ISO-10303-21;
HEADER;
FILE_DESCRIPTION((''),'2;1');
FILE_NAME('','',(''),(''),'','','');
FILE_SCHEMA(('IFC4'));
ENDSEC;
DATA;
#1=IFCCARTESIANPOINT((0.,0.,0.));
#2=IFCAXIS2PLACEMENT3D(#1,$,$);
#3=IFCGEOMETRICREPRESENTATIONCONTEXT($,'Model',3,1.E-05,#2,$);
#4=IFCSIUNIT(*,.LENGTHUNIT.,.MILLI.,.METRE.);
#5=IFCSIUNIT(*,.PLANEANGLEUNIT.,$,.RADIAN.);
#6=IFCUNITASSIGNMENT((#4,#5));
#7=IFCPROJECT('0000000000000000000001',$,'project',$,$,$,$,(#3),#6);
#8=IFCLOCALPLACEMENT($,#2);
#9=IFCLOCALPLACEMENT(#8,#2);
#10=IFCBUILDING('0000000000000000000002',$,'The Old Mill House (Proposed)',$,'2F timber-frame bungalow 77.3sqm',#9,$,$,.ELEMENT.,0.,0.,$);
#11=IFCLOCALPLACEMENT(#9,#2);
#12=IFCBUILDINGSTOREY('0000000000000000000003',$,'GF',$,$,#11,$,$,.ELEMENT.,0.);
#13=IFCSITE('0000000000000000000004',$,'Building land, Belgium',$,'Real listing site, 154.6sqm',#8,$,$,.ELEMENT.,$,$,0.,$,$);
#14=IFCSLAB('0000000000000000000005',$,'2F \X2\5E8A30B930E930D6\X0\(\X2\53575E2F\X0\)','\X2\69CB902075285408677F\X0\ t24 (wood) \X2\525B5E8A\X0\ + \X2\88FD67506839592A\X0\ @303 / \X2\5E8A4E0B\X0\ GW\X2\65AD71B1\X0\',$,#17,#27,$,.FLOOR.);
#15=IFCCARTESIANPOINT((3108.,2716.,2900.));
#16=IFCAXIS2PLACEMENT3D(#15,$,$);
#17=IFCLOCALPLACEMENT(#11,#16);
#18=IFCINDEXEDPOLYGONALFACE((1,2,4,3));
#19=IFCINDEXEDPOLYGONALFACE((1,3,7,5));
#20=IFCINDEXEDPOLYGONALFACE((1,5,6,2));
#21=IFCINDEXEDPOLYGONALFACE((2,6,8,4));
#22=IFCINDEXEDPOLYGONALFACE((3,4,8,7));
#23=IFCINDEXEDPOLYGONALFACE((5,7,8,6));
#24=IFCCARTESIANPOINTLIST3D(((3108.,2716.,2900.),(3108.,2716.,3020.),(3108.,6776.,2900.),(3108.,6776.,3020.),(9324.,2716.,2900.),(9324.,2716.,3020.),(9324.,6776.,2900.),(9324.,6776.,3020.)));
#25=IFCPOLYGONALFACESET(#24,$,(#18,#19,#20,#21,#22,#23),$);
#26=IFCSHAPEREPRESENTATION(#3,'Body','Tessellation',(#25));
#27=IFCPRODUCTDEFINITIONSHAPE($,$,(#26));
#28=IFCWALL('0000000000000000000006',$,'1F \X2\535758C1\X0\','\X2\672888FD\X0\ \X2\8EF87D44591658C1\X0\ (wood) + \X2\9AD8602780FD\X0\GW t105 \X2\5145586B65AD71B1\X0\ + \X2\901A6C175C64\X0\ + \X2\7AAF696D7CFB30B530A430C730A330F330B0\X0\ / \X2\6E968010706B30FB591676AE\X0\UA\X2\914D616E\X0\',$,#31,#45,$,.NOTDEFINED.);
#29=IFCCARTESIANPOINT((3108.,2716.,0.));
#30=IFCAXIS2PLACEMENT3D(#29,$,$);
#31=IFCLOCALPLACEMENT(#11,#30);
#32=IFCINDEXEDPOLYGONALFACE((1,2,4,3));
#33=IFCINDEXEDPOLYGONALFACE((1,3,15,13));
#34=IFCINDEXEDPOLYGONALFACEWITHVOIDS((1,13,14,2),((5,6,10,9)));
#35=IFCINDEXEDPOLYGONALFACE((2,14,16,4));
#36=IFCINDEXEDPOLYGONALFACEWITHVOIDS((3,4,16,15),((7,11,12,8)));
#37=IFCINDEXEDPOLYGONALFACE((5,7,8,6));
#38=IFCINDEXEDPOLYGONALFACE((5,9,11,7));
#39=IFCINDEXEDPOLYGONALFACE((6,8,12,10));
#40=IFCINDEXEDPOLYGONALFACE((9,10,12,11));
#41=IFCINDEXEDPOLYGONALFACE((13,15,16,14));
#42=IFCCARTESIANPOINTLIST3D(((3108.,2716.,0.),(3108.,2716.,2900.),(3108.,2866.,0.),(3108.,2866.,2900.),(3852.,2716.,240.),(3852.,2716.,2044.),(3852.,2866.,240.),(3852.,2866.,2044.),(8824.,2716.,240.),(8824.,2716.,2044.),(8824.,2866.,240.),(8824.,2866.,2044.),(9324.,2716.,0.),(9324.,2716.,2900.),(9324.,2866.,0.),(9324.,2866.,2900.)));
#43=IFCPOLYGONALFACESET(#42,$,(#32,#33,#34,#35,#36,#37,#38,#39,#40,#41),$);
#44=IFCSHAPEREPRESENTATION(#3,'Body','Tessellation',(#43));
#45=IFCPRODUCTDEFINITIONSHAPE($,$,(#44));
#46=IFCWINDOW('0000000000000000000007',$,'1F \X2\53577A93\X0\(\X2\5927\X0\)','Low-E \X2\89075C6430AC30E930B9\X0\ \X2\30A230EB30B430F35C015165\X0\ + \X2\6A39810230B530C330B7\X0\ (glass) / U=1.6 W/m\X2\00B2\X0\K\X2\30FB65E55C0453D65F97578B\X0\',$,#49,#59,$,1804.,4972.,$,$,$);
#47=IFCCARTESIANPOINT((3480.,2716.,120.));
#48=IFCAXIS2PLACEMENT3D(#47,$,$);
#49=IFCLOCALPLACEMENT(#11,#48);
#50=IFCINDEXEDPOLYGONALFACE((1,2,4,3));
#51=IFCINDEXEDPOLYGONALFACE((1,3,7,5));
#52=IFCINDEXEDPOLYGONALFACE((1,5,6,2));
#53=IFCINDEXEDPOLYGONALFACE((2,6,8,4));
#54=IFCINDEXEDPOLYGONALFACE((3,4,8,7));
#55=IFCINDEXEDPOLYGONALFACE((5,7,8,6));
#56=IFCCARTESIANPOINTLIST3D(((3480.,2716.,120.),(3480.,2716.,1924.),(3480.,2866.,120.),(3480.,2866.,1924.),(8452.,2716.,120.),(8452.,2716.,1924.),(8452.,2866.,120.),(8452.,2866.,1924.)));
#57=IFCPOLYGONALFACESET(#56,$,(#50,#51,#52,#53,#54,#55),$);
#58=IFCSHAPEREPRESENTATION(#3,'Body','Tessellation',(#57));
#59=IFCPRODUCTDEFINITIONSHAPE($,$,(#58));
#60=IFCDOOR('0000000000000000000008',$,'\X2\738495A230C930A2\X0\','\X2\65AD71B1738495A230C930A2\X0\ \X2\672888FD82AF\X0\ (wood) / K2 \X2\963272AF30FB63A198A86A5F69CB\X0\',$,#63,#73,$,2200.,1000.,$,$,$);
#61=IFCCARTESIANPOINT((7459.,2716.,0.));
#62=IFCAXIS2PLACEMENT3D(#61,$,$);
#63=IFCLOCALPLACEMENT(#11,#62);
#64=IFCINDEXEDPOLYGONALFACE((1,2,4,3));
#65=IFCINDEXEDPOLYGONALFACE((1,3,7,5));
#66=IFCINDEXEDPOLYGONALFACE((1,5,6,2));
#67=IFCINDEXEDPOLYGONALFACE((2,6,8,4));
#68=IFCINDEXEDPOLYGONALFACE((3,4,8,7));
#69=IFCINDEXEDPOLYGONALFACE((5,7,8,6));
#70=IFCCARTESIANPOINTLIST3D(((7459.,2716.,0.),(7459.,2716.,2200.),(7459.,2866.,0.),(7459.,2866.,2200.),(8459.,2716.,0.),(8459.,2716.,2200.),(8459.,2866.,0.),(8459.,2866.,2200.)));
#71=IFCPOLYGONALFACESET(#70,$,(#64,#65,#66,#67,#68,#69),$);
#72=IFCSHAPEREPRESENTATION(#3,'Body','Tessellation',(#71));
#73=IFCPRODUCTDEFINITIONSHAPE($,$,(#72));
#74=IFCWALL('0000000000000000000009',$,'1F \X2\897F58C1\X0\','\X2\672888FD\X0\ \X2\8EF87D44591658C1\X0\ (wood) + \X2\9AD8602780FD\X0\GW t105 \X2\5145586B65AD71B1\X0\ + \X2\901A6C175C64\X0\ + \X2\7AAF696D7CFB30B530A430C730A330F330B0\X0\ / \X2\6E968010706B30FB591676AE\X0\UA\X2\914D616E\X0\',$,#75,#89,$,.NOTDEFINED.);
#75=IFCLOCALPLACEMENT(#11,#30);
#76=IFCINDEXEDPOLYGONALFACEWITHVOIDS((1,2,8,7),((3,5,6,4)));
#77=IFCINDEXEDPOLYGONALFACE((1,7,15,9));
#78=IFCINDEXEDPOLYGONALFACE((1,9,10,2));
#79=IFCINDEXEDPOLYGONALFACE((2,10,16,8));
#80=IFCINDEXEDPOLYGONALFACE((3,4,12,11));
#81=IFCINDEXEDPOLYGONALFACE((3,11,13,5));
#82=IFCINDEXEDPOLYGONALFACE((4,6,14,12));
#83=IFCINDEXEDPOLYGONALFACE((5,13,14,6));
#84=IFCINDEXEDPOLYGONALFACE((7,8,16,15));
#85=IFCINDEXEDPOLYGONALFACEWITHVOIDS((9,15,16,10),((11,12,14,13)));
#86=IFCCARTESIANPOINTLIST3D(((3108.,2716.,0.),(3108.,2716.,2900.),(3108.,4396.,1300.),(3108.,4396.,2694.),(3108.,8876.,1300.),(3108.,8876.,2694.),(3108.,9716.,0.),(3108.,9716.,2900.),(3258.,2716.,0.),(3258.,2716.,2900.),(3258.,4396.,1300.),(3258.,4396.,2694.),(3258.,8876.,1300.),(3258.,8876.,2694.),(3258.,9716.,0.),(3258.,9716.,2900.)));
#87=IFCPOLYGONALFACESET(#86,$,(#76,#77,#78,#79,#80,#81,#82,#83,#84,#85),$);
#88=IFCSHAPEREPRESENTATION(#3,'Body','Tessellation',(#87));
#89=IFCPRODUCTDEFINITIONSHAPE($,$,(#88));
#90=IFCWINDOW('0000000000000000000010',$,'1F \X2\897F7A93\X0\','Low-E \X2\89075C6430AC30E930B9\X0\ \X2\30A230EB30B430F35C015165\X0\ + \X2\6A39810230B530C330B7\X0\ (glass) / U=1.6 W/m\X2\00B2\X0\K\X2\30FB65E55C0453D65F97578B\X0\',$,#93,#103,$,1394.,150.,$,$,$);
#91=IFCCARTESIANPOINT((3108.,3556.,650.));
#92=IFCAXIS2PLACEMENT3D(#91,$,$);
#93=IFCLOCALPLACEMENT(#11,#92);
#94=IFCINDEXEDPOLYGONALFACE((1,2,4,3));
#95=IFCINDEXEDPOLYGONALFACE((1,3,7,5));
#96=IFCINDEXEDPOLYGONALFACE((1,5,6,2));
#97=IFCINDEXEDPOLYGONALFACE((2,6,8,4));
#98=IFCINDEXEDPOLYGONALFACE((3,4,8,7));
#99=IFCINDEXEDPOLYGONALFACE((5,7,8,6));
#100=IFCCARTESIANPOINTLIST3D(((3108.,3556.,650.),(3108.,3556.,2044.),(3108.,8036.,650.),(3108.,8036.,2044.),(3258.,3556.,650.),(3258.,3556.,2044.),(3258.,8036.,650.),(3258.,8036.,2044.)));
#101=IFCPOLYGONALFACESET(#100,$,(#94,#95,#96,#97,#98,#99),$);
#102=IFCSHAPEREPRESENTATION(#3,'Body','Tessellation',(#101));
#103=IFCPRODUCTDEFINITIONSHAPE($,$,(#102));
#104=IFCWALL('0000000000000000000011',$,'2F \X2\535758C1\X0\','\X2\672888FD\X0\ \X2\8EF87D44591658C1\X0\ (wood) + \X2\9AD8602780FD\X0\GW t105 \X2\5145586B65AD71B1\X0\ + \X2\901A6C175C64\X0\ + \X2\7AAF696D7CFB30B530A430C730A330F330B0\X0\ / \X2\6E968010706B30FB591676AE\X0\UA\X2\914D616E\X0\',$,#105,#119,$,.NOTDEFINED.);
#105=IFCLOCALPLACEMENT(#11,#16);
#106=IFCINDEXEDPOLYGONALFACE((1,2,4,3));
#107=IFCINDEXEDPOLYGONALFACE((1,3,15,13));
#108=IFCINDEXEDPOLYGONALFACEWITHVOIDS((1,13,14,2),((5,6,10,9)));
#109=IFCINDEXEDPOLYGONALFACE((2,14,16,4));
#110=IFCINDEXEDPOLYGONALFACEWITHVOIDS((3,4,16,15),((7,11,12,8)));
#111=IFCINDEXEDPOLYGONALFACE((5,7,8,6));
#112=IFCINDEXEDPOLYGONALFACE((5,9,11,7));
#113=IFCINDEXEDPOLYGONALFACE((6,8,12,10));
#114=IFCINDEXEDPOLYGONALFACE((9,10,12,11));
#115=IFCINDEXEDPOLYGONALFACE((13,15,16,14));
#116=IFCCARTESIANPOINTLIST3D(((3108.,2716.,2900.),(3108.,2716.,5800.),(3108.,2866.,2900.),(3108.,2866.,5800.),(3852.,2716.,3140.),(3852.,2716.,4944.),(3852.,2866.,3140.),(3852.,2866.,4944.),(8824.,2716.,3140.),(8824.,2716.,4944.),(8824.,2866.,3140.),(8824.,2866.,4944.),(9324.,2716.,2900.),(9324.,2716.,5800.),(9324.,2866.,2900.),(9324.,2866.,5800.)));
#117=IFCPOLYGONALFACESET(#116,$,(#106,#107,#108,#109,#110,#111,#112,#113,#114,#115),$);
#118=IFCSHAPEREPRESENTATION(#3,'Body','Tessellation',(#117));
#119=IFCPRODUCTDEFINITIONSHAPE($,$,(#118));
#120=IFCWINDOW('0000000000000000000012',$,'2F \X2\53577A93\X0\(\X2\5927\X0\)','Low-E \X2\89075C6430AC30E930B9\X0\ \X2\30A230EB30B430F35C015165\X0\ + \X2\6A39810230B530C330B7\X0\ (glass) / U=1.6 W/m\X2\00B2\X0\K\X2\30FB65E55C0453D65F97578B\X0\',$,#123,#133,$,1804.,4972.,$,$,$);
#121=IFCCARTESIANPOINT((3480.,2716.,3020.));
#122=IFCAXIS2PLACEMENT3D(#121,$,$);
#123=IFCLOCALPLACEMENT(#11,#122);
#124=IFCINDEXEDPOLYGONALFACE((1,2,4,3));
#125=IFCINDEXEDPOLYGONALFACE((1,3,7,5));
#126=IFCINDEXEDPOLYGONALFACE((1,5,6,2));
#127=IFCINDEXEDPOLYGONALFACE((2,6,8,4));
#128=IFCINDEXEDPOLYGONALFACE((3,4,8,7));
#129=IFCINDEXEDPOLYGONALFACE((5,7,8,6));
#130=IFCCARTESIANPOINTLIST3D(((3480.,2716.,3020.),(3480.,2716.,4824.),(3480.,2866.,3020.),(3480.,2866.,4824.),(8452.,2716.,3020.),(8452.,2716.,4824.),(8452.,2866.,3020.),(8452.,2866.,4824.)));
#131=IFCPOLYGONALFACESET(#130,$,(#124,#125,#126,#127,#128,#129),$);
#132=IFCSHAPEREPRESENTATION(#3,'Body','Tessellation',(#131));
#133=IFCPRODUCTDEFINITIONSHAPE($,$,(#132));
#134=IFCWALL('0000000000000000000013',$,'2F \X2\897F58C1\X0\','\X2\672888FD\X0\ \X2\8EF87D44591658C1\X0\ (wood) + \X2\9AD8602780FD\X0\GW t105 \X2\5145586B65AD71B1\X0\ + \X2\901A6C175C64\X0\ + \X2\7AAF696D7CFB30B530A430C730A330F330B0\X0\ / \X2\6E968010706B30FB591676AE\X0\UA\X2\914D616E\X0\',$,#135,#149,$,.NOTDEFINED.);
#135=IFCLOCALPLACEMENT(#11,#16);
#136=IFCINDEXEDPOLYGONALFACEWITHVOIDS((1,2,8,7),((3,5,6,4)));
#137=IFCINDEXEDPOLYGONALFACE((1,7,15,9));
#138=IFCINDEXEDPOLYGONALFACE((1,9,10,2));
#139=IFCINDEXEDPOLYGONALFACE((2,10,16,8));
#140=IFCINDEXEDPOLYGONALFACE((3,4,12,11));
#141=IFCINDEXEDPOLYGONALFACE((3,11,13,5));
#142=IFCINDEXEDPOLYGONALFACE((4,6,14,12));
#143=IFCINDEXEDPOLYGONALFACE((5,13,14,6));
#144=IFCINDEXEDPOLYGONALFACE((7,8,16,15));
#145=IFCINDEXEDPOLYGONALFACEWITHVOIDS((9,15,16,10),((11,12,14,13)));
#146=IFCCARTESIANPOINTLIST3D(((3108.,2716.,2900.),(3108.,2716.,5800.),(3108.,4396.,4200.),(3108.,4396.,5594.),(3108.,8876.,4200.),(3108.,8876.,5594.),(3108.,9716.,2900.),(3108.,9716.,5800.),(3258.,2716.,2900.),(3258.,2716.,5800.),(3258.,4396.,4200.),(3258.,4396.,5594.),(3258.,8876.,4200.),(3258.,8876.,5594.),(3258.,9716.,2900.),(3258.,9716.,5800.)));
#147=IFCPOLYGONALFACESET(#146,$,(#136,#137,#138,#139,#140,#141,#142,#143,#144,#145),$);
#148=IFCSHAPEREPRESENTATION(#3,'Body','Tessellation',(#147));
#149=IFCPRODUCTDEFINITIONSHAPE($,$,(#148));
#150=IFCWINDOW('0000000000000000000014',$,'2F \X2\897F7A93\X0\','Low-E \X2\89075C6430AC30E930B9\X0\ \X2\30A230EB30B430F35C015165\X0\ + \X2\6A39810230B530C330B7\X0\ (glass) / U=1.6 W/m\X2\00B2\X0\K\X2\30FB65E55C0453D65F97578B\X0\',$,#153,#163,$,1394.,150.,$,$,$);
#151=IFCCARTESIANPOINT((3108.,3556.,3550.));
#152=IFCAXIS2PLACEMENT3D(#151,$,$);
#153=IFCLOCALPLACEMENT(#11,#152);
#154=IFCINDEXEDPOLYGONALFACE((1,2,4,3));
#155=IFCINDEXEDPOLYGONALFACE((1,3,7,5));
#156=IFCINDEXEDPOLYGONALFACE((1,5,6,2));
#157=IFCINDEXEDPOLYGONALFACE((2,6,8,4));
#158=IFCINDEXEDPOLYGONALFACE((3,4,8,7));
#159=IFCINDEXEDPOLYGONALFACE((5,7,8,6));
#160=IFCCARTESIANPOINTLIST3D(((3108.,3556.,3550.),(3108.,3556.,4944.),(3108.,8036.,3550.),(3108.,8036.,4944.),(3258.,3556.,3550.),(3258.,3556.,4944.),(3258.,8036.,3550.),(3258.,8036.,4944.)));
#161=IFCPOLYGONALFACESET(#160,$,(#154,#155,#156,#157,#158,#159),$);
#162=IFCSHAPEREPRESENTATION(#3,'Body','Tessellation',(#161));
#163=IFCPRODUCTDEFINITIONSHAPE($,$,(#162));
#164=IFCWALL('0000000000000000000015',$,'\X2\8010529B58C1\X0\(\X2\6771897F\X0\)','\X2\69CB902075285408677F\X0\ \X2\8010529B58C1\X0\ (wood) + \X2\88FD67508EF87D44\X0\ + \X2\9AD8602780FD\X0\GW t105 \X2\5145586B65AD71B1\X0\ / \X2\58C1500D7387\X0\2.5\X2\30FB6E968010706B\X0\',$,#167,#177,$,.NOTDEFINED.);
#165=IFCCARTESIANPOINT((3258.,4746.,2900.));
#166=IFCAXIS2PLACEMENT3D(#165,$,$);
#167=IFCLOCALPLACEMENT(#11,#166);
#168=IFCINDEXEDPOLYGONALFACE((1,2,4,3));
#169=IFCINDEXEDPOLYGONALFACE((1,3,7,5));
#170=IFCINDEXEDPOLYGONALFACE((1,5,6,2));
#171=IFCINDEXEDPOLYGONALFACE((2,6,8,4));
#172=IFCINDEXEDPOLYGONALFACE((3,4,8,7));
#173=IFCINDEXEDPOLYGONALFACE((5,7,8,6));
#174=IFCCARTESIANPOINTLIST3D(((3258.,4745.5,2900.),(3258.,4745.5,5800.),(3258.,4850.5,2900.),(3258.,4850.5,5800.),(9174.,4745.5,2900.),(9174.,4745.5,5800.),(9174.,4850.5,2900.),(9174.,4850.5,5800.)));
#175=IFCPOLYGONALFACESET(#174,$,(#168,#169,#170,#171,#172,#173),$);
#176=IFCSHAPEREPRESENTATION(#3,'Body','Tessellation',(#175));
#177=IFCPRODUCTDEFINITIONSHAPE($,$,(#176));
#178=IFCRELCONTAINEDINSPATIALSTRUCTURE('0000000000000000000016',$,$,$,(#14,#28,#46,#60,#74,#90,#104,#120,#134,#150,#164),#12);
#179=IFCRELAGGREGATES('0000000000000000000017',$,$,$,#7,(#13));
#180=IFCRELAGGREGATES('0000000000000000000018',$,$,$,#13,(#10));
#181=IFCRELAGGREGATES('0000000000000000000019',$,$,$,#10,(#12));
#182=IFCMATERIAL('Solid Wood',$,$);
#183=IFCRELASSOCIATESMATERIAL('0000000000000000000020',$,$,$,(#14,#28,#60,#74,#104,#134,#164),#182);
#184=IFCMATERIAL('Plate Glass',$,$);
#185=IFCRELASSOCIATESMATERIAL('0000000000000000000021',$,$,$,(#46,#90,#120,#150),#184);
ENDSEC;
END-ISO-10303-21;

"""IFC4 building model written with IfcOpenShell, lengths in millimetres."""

from ifc_helpers import new_model, si_unit, frame, frame_2d, origin, place, context, project, spatial, rectangle, extrude, material, element, fill, save


model = new_model("IFC4")

# Units and contexts
model_context = context("Model", 3, precision=1e-05, world=origin())
ifc_project = project(units=[si_unit("LENGTHUNIT", "METRE", prefix="MILLI"), si_unit("PLANEANGLEUNIT", "RADIAN")], contexts=[model_context])

# Site, building, storey
site_placement = place(None, origin())
site = spatial("IfcSite", under=ifc_project, at=site_placement, Name="Building land, Belgium", ObjectType="Real listing site, 154.6sqm", CompositionType="ELEMENT", RefElevation=0.0)
building_placement = place(site_placement, origin())
building = spatial("IfcBuilding", under=site, at=building_placement, Name="The Old Mill House (Proposed)", ObjectType="2F timber-frame bungalow 77.3sqm", CompositionType="ELEMENT", ElevationOfRefHeight=0.0, ElevationOfTerrain=0.0)
storey_placement = place(building_placement, origin())
storey = spatial("IfcBuildingStorey", under=building, at=storey_placement, Name="GF", CompositionType="ELEMENT", Elevation=0.0)

# Slab
ifc_material_1 = material(Name="Solid Wood")
slab_1_placement = place(storey_placement, frame((3108.0, 2716.0, 2900.0)))
element("IfcSlab", 1, at=slab_1_placement, inside=storey, material=ifc_material_1, Name="2F 床スラブ(南帯)", Description="構造用合板 t24 (wood) 剛床 + 製材根太 @303 / 床下 GW断熱", PredefinedType="FLOOR", context=model_context, shape_type="SweptSolid", body=[
    extrude(rectangle(XDim=6216.0, YDim=4060.0, at=frame_2d((3108.0, 2030.0))), frame((3108.0, 2716.0, 2900.0)), (0.0, 0.0, 1.0), 120.0),
])

# Wall, openings, window, door
wall_1_placement = place(storey_placement, frame((3108.0, 2716.0, 0.0)))
wall_1 = element("IfcWall", 2, at=wall_1_placement, inside=storey, material=ifc_material_1, Name="1F 南壁", Description="木製 軸組外壁 (wood) + 高性能GW t105 充填断熱 + 通気層 + 窯業系サイディング / 準耐火・外皮UA配慮", PredefinedType="NOTDEFINED", context=model_context, shape_type="SweptSolid", body=[
    extrude(rectangle(XDim=6216.0, YDim=150.0, at=frame_2d((3108.0, 75.0))), frame((3108.0, 2716.0, 0.0)), (0.0, 0.0, 1.0), 2900.0),
])
opening_1_placement = place(storey_placement, frame((3480.0, 2716.0, 120.0)))
opening_1 = element("IfcOpeningElement", 3, at=opening_1_placement, cuts=wall_1, PredefinedType="NOTDEFINED", context=model_context, shape_type="SweptSolid", body=[
    extrude(rectangle(XDim=4972.0, YDim=150.0, at=frame_2d((2486.0, 75.0))), frame((3480.0, 2716.0, 120.0)), (0.0, 0.0, 1.0), 1804.0),
])
opening_2_placement = place(storey_placement, frame((7459.0, 2716.0, 0.0)))
opening_2 = element("IfcOpeningElement", 4, at=opening_2_placement, cuts=wall_1, PredefinedType="NOTDEFINED", context=model_context, shape_type="SweptSolid", body=[
    extrude(rectangle(XDim=1000.0, YDim=150.0, at=frame_2d((500.0, 75.0))), frame((7459.0, 2716.0, 0.0)), (0.0, 0.0, 1.0), 2200.0),
])
ifc_material_2 = material(Name="Plate Glass")
window_1_placement = place(storey_placement, frame((3480.0, 2716.0, 120.0)))
window_1 = element("IfcWindow", 5, at=window_1_placement, inside=storey, material=ifc_material_2, Name="1F 南窓(大)", Description="Low-E 複層ガラス アルゴン封入 + 樹脂サッシ (glass) / U=1.6 W/m²K・日射取得型", OverallHeight=1804.0, OverallWidth=4972.0, context=model_context, shape_type="SweptSolid", body=[
    extrude(rectangle(XDim=4972.0, YDim=150.0, at=frame_2d((2486.0, 75.0))), frame((3480.0, 2716.0, 120.0)), (0.0, 0.0, 1.0), 1804.0),
])
fill(opening_1, window_1)
door_placement = place(storey_placement, frame((7459.0, 2716.0, 0.0)))
door = element("IfcDoor", 6, at=door_placement, inside=storey, material=ifc_material_1, Name="玄関ドア", Description="断熱玄関ドア 木製芯 (wood) / K2 防犯・採風機構", OverallHeight=2200.0, OverallWidth=1000.0, context=model_context, shape_type="SweptSolid", body=[
    extrude(rectangle(XDim=1000.0, YDim=150.0, at=frame_2d((500.0, 75.0))), frame((7459.0, 2716.0, 0.0)), (0.0, 0.0, 1.0), 2200.0),
])
fill(opening_2, door)

# Wall, opening, window
wall_2_placement = place(storey_placement, frame((3108.0, 2716.0, 0.0)))
wall_2 = element("IfcWall", 7, at=wall_2_placement, inside=storey, material=ifc_material_1, Name="1F 西壁", Description="木製 軸組外壁 (wood) + 高性能GW t105 充填断熱 + 通気層 + 窯業系サイディング / 準耐火・外皮UA配慮", PredefinedType="NOTDEFINED", context=model_context, shape_type="SweptSolid", body=[
    extrude(rectangle(XDim=150.0, YDim=7000.0, at=frame_2d((75.0, 3500.0))), frame((3108.0, 2716.0, 0.0)), (0.0, 0.0, 1.0), 2900.0),
])
opening_3_placement = place(storey_placement, frame((3108.0, 3556.0, 650.0)))
opening_3 = element("IfcOpeningElement", 8, at=opening_3_placement, cuts=wall_2, PredefinedType="NOTDEFINED", context=model_context, shape_type="SweptSolid", body=[
    extrude(rectangle(XDim=150.0, YDim=4480.0, at=frame_2d((75.0, 2240.0))), frame((3108.0, 3556.0, 650.0)), (0.0, 0.0, 1.0), 1394.0),
])
window_2_placement = place(storey_placement, frame((3108.0, 3556.0, 650.0)))
window_2 = element("IfcWindow", 9, at=window_2_placement, inside=storey, material=ifc_material_2, Name="1F 西窓", Description="Low-E 複層ガラス アルゴン封入 + 樹脂サッシ (glass) / U=1.6 W/m²K・日射取得型", OverallHeight=1394.0, OverallWidth=150.0, context=model_context, shape_type="SweptSolid", body=[
    extrude(rectangle(XDim=150.0, YDim=4480.0, at=frame_2d((75.0, 2240.0))), frame((3108.0, 3556.0, 650.0)), (0.0, 0.0, 1.0), 1394.0),
])
fill(opening_3, window_2)

# Walls, openings, windows
wall_3_placement = place(storey_placement, frame((3108.0, 2716.0, 2900.0)))
wall_3 = element("IfcWall", 10, at=wall_3_placement, inside=storey, material=ifc_material_1, Name="2F 南壁", Description="木製 軸組外壁 (wood) + 高性能GW t105 充填断熱 + 通気層 + 窯業系サイディング / 準耐火・外皮UA配慮", PredefinedType="NOTDEFINED", context=model_context, shape_type="SweptSolid", body=[
    extrude(rectangle(XDim=6216.0, YDim=150.0, at=frame_2d((3108.0, 75.0))), frame((3108.0, 2716.0, 2900.0)), (0.0, 0.0, 1.0), 2900.0),
])
opening_4_placement = place(storey_placement, frame((3480.0, 2716.0, 3020.0)))
opening_4 = element("IfcOpeningElement", 11, at=opening_4_placement, cuts=wall_3, PredefinedType="NOTDEFINED", context=model_context, shape_type="SweptSolid", body=[
    extrude(rectangle(XDim=4972.0, YDim=150.0, at=frame_2d((2486.0, 75.0))), frame((3480.0, 2716.0, 3020.0)), (0.0, 0.0, 1.0), 1804.0),
])
window_3_placement = place(storey_placement, frame((3480.0, 2716.0, 3020.0)))
window_3 = element("IfcWindow", 12, at=window_3_placement, inside=storey, material=ifc_material_2, Name="2F 南窓(大)", Description="Low-E 複層ガラス アルゴン封入 + 樹脂サッシ (glass) / U=1.6 W/m²K・日射取得型", OverallHeight=1804.0, OverallWidth=4972.0, context=model_context, shape_type="SweptSolid", body=[
    extrude(rectangle(XDim=4972.0, YDim=150.0, at=frame_2d((2486.0, 75.0))), frame((3480.0, 2716.0, 3020.0)), (0.0, 0.0, 1.0), 1804.0),
])
fill(opening_4, window_3)
wall_4_placement = place(storey_placement, frame((3108.0, 2716.0, 2900.0)))
wall_4 = element("IfcWall", 13, at=wall_4_placement, inside=storey, material=ifc_material_1, Name="2F 西壁", Description="木製 軸組外壁 (wood) + 高性能GW t105 充填断熱 + 通気層 + 窯業系サイディング / 準耐火・外皮UA配慮", PredefinedType="NOTDEFINED", context=model_context, shape_type="SweptSolid", body=[
    extrude(rectangle(XDim=150.0, YDim=7000.0, at=frame_2d((75.0, 3500.0))), frame((3108.0, 2716.0, 2900.0)), (0.0, 0.0, 1.0), 2900.0),
])
opening_5_placement = place(storey_placement, frame((3108.0, 3556.0, 3550.0)))
opening_5 = element("IfcOpeningElement", 14, at=opening_5_placement, cuts=wall_4, PredefinedType="NOTDEFINED", context=model_context, shape_type="SweptSolid", body=[
    extrude(rectangle(XDim=150.0, YDim=4480.0, at=frame_2d((75.0, 2240.0))), frame((3108.0, 3556.0, 3550.0)), (0.0, 0.0, 1.0), 1394.0),
])
window_4_placement = place(storey_placement, frame((3108.0, 3556.0, 3550.0)))
window_4 = element("IfcWindow", 15, at=window_4_placement, inside=storey, material=ifc_material_2, Name="2F 西窓", Description="Low-E 複層ガラス アルゴン封入 + 樹脂サッシ (glass) / U=1.6 W/m²K・日射取得型", OverallHeight=1394.0, OverallWidth=150.0, context=model_context, shape_type="SweptSolid", body=[
    extrude(rectangle(XDim=150.0, YDim=4480.0, at=frame_2d((75.0, 2240.0))), frame((3108.0, 3556.0, 3550.0)), (0.0, 0.0, 1.0), 1394.0),
])
fill(opening_5, window_4)

# Wall
wall_5_placement = place(storey_placement, frame((3258.0, 4746.0, 2900.0)))
element("IfcWall", 16, at=wall_5_placement, inside=storey, material=ifc_material_1, Name="耐力壁(東西)", Description="構造用合板 耐力壁 (wood) + 製材軸組 + 高性能GW t105 充填断熱 / 壁倍率2.5・準耐火", PredefinedType="NOTDEFINED", context=model_context, shape_type="SweptSolid", body=[
    extrude(rectangle(XDim=5916.0, YDim=105.0, at=frame_2d((2958.0, 52.0))), frame((3258.0, 4746.0, 2900.0)), (0.0, 0.0, 1.0), 2900.0),
])

save(model, "model.ifc")
